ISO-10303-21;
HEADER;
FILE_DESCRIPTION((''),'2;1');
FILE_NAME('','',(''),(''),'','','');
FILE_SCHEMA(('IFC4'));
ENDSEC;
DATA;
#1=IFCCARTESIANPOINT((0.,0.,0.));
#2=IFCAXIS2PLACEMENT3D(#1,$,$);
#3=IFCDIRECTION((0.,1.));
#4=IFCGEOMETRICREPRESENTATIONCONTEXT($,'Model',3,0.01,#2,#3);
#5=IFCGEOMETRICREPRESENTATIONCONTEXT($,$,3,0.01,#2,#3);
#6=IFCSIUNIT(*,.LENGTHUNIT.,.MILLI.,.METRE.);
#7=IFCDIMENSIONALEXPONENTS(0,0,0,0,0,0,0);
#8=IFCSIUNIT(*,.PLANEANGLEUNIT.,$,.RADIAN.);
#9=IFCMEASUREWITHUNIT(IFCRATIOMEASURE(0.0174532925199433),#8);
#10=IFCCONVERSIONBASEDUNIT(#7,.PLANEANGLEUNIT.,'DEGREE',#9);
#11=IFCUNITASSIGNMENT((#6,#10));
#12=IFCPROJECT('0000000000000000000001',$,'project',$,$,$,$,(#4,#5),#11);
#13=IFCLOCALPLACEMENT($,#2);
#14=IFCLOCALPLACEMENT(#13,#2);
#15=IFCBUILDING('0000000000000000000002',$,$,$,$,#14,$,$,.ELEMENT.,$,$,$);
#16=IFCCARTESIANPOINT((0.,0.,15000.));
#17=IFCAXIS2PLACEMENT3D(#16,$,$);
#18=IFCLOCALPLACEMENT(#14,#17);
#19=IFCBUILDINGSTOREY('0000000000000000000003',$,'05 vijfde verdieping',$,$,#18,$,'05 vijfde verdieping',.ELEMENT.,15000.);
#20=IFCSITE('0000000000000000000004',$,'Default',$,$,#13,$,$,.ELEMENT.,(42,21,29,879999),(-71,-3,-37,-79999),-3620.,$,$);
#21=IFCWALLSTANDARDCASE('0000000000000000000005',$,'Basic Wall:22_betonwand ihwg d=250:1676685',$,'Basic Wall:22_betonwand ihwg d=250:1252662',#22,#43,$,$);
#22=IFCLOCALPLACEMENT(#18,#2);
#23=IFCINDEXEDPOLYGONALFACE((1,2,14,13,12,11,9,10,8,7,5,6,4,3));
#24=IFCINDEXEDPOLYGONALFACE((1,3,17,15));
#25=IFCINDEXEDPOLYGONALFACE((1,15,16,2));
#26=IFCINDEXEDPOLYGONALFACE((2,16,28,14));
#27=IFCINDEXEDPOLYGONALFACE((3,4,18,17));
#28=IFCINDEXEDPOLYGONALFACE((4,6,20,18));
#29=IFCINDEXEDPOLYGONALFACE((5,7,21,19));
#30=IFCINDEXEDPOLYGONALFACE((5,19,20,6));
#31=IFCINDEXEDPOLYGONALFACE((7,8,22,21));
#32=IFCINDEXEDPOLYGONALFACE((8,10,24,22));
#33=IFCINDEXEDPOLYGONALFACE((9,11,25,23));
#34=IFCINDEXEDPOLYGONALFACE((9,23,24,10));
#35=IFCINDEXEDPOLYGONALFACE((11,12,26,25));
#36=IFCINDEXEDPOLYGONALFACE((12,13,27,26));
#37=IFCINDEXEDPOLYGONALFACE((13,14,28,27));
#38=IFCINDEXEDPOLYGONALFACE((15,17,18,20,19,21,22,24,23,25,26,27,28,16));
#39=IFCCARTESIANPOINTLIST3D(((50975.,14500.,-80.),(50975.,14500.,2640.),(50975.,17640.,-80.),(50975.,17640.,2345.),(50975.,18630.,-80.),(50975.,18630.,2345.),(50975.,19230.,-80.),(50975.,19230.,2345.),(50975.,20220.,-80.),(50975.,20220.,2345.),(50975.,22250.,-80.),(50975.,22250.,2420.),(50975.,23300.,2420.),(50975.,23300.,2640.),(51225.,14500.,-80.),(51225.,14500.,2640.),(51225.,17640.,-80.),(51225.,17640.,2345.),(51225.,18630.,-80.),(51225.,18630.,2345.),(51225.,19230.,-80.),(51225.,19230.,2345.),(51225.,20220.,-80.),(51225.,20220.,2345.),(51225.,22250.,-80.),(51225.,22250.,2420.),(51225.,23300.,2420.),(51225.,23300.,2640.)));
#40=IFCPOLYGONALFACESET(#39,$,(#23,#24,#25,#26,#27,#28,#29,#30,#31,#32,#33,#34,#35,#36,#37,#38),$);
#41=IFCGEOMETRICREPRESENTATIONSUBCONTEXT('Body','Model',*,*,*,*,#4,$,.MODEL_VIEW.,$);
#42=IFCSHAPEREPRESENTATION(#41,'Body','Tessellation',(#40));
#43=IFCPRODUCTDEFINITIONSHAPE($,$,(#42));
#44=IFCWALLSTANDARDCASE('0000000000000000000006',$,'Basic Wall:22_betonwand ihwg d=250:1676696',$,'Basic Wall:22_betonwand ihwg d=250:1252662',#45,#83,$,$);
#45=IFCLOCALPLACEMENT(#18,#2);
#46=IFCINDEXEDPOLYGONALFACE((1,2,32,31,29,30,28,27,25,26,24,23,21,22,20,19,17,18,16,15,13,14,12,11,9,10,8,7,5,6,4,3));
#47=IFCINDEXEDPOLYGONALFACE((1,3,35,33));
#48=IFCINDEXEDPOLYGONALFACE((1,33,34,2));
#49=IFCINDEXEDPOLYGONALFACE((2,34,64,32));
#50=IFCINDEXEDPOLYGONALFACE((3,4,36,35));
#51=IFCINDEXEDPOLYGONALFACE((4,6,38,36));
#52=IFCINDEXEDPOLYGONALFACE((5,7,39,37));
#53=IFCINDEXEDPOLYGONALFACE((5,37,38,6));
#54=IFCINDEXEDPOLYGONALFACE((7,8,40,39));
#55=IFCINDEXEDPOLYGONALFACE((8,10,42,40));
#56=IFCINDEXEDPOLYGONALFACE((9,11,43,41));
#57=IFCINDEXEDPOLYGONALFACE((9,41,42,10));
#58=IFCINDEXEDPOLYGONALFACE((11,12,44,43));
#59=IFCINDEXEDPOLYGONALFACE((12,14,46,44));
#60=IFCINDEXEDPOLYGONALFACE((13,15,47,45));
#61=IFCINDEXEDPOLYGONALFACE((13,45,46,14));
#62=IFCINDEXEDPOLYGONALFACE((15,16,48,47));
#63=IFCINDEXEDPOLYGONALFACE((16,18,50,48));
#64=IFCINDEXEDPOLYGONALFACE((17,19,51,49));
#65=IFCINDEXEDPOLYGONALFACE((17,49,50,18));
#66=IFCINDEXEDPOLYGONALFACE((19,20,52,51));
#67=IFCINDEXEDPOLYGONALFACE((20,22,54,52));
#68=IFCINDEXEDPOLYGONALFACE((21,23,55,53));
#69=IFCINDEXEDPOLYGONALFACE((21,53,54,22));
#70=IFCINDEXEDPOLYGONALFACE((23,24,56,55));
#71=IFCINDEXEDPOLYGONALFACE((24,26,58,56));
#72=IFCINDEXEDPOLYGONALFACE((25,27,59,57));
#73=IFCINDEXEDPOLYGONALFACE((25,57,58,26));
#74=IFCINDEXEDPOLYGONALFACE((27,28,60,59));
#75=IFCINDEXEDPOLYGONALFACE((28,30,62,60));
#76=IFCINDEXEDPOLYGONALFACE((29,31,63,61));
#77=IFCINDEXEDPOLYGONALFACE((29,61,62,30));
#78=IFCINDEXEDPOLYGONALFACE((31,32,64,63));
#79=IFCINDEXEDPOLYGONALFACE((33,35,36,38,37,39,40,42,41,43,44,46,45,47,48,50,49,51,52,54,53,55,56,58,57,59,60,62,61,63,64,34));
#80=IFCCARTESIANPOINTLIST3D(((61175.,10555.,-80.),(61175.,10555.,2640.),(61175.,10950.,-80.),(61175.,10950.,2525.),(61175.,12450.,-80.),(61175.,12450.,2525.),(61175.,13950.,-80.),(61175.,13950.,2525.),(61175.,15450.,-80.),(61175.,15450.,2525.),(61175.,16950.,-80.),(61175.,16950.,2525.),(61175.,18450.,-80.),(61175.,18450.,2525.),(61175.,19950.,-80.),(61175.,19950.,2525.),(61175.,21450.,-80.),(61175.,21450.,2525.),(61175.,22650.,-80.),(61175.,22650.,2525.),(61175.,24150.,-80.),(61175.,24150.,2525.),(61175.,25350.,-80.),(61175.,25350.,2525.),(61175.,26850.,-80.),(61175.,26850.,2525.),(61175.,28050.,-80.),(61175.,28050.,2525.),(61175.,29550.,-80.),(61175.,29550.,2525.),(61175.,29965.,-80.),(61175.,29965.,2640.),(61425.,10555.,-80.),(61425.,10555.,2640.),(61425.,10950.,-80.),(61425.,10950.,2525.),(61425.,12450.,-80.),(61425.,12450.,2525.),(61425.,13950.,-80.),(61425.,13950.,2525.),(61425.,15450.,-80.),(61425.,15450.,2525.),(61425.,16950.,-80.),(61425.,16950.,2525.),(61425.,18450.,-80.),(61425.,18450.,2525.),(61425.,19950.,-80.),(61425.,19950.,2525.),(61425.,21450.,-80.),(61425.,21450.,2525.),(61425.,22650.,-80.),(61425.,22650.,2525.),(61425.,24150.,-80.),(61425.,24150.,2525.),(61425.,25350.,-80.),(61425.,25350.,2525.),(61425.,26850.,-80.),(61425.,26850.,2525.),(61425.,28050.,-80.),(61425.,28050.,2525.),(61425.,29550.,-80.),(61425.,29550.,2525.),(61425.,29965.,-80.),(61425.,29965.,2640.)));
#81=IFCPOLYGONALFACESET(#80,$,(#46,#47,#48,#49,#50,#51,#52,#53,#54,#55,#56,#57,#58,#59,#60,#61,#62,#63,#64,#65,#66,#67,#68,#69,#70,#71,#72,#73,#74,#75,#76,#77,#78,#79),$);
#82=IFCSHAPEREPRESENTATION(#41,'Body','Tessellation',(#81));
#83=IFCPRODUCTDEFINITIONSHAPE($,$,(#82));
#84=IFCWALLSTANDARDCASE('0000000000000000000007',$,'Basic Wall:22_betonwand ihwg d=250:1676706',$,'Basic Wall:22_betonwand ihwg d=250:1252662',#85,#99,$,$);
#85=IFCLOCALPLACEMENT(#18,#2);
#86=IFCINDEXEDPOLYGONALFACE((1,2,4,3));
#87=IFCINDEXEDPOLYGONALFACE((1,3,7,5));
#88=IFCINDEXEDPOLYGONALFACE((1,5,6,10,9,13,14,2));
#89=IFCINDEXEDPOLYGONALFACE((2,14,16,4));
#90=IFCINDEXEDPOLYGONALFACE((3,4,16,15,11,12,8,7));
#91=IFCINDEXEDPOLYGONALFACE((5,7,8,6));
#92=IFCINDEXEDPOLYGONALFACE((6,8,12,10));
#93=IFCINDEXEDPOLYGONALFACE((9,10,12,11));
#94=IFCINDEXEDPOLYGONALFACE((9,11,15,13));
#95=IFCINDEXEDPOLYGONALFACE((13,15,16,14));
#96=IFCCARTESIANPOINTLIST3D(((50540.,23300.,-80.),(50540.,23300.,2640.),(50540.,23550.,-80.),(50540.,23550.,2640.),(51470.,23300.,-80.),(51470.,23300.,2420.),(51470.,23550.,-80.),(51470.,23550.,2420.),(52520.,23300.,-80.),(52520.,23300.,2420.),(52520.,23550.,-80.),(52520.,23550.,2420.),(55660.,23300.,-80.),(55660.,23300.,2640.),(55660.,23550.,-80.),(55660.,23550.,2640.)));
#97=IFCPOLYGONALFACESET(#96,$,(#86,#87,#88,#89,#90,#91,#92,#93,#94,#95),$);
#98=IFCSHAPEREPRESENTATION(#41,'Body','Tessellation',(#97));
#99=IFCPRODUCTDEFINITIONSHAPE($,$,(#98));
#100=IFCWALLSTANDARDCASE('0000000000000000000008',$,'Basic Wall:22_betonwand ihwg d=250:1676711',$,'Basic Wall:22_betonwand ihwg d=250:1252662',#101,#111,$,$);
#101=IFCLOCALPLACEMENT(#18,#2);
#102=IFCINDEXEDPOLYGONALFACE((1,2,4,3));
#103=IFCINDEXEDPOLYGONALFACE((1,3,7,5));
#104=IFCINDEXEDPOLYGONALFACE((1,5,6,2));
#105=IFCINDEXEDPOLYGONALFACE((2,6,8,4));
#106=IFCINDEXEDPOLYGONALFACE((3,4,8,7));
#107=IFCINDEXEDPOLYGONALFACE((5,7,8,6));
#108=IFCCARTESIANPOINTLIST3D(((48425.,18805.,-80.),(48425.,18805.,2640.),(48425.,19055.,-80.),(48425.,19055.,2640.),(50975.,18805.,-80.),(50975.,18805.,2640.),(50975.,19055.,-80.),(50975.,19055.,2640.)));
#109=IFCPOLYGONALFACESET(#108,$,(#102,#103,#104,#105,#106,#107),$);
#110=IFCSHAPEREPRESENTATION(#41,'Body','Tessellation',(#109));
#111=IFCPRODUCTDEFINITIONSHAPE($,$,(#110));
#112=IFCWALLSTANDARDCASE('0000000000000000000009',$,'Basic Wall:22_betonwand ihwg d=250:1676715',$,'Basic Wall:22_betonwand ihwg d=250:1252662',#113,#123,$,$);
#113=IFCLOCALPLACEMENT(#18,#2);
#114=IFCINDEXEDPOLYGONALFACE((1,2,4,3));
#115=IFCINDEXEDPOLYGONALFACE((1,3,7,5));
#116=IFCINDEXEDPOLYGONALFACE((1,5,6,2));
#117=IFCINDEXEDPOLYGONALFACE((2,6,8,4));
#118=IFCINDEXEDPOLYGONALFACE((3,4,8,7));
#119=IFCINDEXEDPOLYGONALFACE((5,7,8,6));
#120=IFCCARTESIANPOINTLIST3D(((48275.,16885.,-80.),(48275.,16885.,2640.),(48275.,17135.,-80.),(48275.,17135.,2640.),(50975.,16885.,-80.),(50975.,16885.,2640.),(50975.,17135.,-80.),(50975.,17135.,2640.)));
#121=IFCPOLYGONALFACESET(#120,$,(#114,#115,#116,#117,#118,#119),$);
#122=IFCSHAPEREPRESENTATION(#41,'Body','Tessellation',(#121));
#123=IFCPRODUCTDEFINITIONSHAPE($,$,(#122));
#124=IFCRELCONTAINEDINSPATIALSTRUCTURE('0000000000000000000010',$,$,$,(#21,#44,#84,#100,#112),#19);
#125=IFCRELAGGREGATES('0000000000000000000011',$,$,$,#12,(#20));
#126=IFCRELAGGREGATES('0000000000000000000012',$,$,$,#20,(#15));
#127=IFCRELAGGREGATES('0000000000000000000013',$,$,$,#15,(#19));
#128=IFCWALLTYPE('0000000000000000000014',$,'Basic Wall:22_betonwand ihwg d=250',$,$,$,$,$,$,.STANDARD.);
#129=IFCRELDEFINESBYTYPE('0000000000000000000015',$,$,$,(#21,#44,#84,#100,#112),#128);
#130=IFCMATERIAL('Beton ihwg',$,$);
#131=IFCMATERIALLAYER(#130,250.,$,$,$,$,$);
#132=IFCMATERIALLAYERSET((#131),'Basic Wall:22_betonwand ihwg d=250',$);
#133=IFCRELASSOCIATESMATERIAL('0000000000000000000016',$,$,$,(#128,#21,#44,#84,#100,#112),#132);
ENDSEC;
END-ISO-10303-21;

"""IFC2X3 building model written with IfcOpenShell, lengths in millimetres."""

from ifc_helpers import new_model, entity, si_unit, converted_unit, direction, frame, frame_2d, origin, origin_2d_with_axis, place, context, subcontext, project, spatial, rectangle, extrude, material, layer, layer_set, layer_usage, type_object, element, save


model = new_model("IFC2X3")

# Units and contexts
model_context = context("Model", 3, precision=0.01, world=origin(), true_north=direction((0.0, 1.0)))
context_of_model = context(None, 3, precision=0.01, world=origin(), true_north=direction((0.0, 1.0)))
body_context = subcontext(model_context, "Body", "Model", "MODEL_VIEW")
ifc_project = project(units=[si_unit("LENGTHUNIT", "METRE", prefix="MILLI"), converted_unit("PLANEANGLEUNIT", "DEGREE", entity("IfcRatioMeasure", 0.0174532925199433), si_unit("PLANEANGLEUNIT", "RADIAN"), dimensions=[0, 0, 0, 0, 0, 0, 0])], contexts=[model_context, context_of_model])

# Site, building, storey
site_placement = place(None, origin())
site = spatial("IfcSite", under=ifc_project, at=site_placement, Name="Default", CompositionType="ELEMENT", RefLatitude=(42, 21, 29, 879999), RefLongitude=(-71, -3, -37, -79999), RefElevation=-3620.0)
building_placement = place(site_placement, origin())
building = spatial("IfcBuilding", under=site, at=building_placement, CompositionType="ELEMENT")
storey_placement = place(building_placement, frame((0.0, 0.0, 15000.0)))
storey = spatial("IfcBuildingStorey", under=building, at=storey_placement, Name="05 vijfde verdieping", LongName="05 vijfde verdieping", CompositionType="ELEMENT", Elevation=15000.0)

# Walls, openings
ifc_material_1 = material(Name="Beton ihwg")
ifc_layer_1 = layer(ifc_material_1, 250.0)
ifc_layer_set_1 = layer_set([ifc_layer_1], Name="Basic Wall:22_betonwand ihwg d=250")
ifc_layer_usage_1 = layer_usage(ifc_layer_set_1, "AXIS2", "NEGATIVE", 125.0)
wall_type_1 = type_object("IfcWallType", Name="Basic Wall:22_betonwand ihwg d=250", PredefinedType="STANDARD", material=ifc_layer_set_1)
wall_1_placement = place(storey_placement, frame((51100.0, 23300.0, -80.0), z_axis=(0.0, 0.0, 1.0), x_axis=(0.0, -1.0, 0.0)))
wall_1 = element("IfcWallStandardCase", 1, at=wall_1_placement, inside=storey, type_object=wall_type_1, material=ifc_layer_usage_1, Name="Basic Wall:22_betonwand ihwg d=250:1676685", ObjectType="Basic Wall:22_betonwand ihwg d=250:1252662", context=body_context, shape_type="SweptSolid", body=[
    extrude(rectangle(XDim=8800.0, YDim=250.0, at=frame_2d((4400.0, 0.0), x_axis=(-1.0, 0.0))), origin(), (0.0, 0.0, 1.0), 2720.0),
])
opening_1_placement = place(wall_1_placement, frame((23300.0, -51100.0, 80.0), z_axis=(0.0, 0.0, 1.0), x_axis=(0.0, 1.0, 0.0)))
element("IfcOpeningElement", 2, at=opening_1_placement, cuts=wall_1, ObjectType="Opening", context=body_context, shape_type="SweptSolid", body=[
    extrude(rectangle(XDim=2425.0, YDim=990.0, at=frame_2d((0.0, 0.0), x_axis=(1.0, 0.0))), frame((50700.0, 19725.0, 1132.5), z_axis=(1.0, 0.0, 0.0), x_axis=(0.0, 0.0, -1.0)), (0.0, 0.0, 1.0), 800.0),
])
opening_2_placement = place(wall_1_placement, frame((23300.0, -51100.0, 80.0), z_axis=(0.0, 0.0, 1.0), x_axis=(0.0, 1.0, 0.0)))
element("IfcOpeningElement", 3, at=opening_2_placement, cuts=wall_1, ObjectType="Opening", context=body_context, shape_type="SweptSolid", body=[
    extrude(rectangle(XDim=2425.0, YDim=990.0, at=origin_2d_with_axis()), frame((50700.0, 18135.0, 1132.5), z_axis=(1.0, 0.0, 0.0), x_axis=(0.0, 0.0, -1.0)), (0.0, 0.0, 1.0), 800.0),
])
opening_3_placement = place(wall_1_placement, frame((23300.0, -51100.0, 80.0), z_axis=(0.0, 0.0, 1.0), x_axis=(0.0, 1.0, 0.0)))
element("IfcOpeningElement", 4, at=opening_3_placement, cuts=wall_1, ObjectType="Opening", context=body_context, shape_type="SweptSolid", body=[
    extrude(rectangle(XDim=2500.0, YDim=1050.0, at=frame_2d((0.0, 0.0), x_axis=(1.0, 0.0))), frame((50700.0, 22775.0, 1170.0), z_axis=(1.0, 0.0, 0.0), x_axis=(0.0, 0.0, -1.0)), (0.0, 0.0, 1.0), 800.0),
])
ifc_layer_usage_2 = layer_usage(ifc_layer_set_1, "AXIS2", "POSITIVE", -125.0)
wall_2_placement = place(storey_placement, frame((61300.0, 29965.0, -80.0), z_axis=(0.0, 0.0, 1.0), x_axis=(0.0, -1.0, 0.0)))
wall_2 = element("IfcWallStandardCase", 5, at=wall_2_placement, inside=storey, type_object=wall_type_1, material=ifc_layer_usage_2, Name="Basic Wall:22_betonwand ihwg d=250:1676696", ObjectType="Basic Wall:22_betonwand ihwg d=250:1252662", context=body_context, shape_type="SweptSolid", body=[
    extrude(rectangle(XDim=19410.0, YDim=250.0, at=frame_2d((9705.0, 0.0), x_axis=(-1.0, 0.0))), origin(), (0.0, 0.0, 1.0), 2720.0),
])
opening_4_placement = place(wall_2_placement, frame((29965.0, -61300.0, 80.0), z_axis=(0.0, 0.0, 1.0), x_axis=(0.0, 1.0, 0.0)))
element("IfcOpeningElement", 6, at=opening_4_placement, cuts=wall_2, ObjectType="Opening", context=body_context, shape_type="SweptSolid", body=[
    extrude(rectangle(XDim=2605.0, YDim=1500.0, at=frame_2d((0.0, 0.0), x_axis=(1.0, 0.0))), frame((59901.0, 28800.0, 1222.5), z_axis=(1.0, 0.0, 0.0), x_axis=(0.0, 0.0, -1.0)), (0.0, 0.0, 1.0), 3048.0),
])
opening_5_placement = place(wall_2_placement, frame((29965.0, -61300.0, 80.0), z_axis=(0.0, 0.0, 1.0), x_axis=(0.0, 1.0, 0.0)))
element("IfcOpeningElement", 7, at=opening_5_placement, cuts=wall_2, ObjectType="Opening", context=body_context, shape_type="SweptSolid", body=[
    extrude(rectangle(XDim=2605.0, YDim=1500.0, at=frame_2d((0.0, 0.0), x_axis=(1.0, 0.0))), frame((59901.0, 26100.0, 1222.5), z_axis=(1.0, 0.0, 0.0), x_axis=(0.0, 0.0, -1.0)), (0.0, 0.0, 1.0), 3048.0),
])
opening_6_placement = place(wall_2_placement, frame((29965.0, -61300.0, 80.0), z_axis=(0.0, 0.0, 1.0), x_axis=(0.0, 1.0, 0.0)))
element("IfcOpeningElement", 8, at=opening_6_placement, cuts=wall_2, ObjectType="Opening", context=body_context, shape_type="SweptSolid", body=[
    extrude(rectangle(XDim=2605.0, YDim=1500.0, at=frame_2d((0.0, 0.0), x_axis=(1.0, 0.0))), frame((59901.0, 23400.0, 1222.5), z_axis=(1.0, 0.0, 0.0), x_axis=(0.0, 0.0, -1.0)), (0.0, 0.0, 1.0), 3048.0),
])
opening_7_placement = place(wall_2_placement, frame((29965.0, -61300.0, 80.0), z_axis=(0.0, 0.0, 1.0), x_axis=(0.0, 1.0, 0.0)))
element("IfcOpeningElement", 9, at=opening_7_placement, cuts=wall_2, ObjectType="Opening", context=body_context, shape_type="SweptSolid", body=[
    extrude(rectangle(XDim=2605.0, YDim=1500.0, at=frame_2d((0.0, 0.0), x_axis=(1.0, 0.0))), frame((59901.0, 17700.0, 1222.5), z_axis=(1.0, 0.0, 0.0), x_axis=(0.0, 0.0, -1.0)), (0.0, 0.0, 1.0), 3048.0),
])
opening_8_placement = place(wall_2_placement, frame((29965.0, -61300.0, 80.0), z_axis=(0.0, 0.0, 1.0), x_axis=(0.0, 1.0, 0.0)))
element("IfcOpeningElement", 10, at=opening_8_placement, cuts=wall_2, ObjectType="Opening", context=body_context, shape_type="SweptSolid", body=[
    extrude(rectangle(XDim=2605.0, YDim=1500.0, at=frame_2d((0.0, 0.0), x_axis=(1.0, 0.0))), frame((59901.0, 14700.0, 1222.5), z_axis=(1.0, 0.0, 0.0), x_axis=(0.0, 0.0, -1.0)), (0.0, 0.0, 1.0), 3048.0),
])
opening_9_placement = place(wall_2_placement, frame((29965.0, -61300.0, 80.0), z_axis=(0.0, 0.0, 1.0), x_axis=(0.0, 1.0, 0.0)))
element("IfcOpeningElement", 11, at=opening_9_placement, cuts=wall_2, ObjectType="Opening", context=body_context, shape_type="SweptSolid", body=[
    extrude(rectangle(XDim=2605.0, YDim=1500.0, at=frame_2d((0.0, 0.0), x_axis=(1.0, 0.0))), frame((59901.0, 20700.0, 1222.5), z_axis=(1.0, 0.0, 0.0), x_axis=(0.0, 0.0, -1.0)), (0.0, 0.0, 1.0), 3048.0),
])
opening_10_placement = place(wall_2_placement, frame((29965.0, -61300.0, 80.0), z_axis=(0.0, 0.0, 1.0), x_axis=(0.0, 1.0, 0.0)))
element("IfcOpeningElement", 12, at=opening_10_placement, cuts=wall_2, ObjectType="Opening", context=body_context, shape_type="SweptSolid", body=[
    extrude(rectangle(XDim=2605.0, YDim=1500.0, at=frame_2d((0.0, 0.0), x_axis=(1.0, 0.0))), frame((59901.0, 11700.0, 1222.5), z_axis=(1.0, 0.0, 0.0), x_axis=(0.0, 0.0, -1.0)), (0.0, 0.0, 1.0), 3048.0),
])
ifc_layer_usage_3 = layer_usage(ifc_layer_set_1, "AXIS2", "POSITIVE", -125.0)
wall_3_placement = place(storey_placement, frame((55660.0, 23425.0, -80.0), z_axis=(0.0, 0.0, 1.0), x_axis=(-1.0, 0.0, 0.0)))
wall_3 = element("IfcWallStandardCase", 13, at=wall_3_placement, inside=storey, type_object=wall_type_1, material=ifc_layer_usage_3, Name="Basic Wall:22_betonwand ihwg d=250:1676706", ObjectType="Basic Wall:22_betonwand ihwg d=250:1252662", context=body_context, shape_type="SweptSolid", body=[
    extrude(rectangle(XDim=5120.0, YDim=250.0, at=frame_2d((2560.0, 0.0), x_axis=(-1.0, 0.0))), origin(), (0.0, 0.0, 1.0), 2720.0),
])
opening_11_placement = place(wall_3_placement, origin())
element("IfcOpeningElement", 14, at=opening_11_placement, cuts=wall_3, ObjectType="Opening", context=body_context, shape_type="SweptSolid", body=[
    extrude(rectangle(XDim=2500.0, YDim=800.0, at=frame_2d((0.0, 0.0), x_axis=(0.0, 1.0))), frame((4560.0, 125.0, 1250.0), z_axis=(0.0, 1.0, 0.0), x_axis=(1.0, 0.0, 0.0)), (0.0, 0.0, 1.0), 1050.0),
])
opening_12_placement = place(wall_3_placement, origin())
element("IfcOpeningElement", 15, at=opening_12_placement, cuts=wall_3, ObjectType="Opening", context=body_context, shape_type="SweptSolid", body=[
    extrude(rectangle(XDim=2500.0, YDim=800.0, at=frame_2d((0.0, 0.0), x_axis=(0.0, 1.0))), frame((2735.0, 125.0, 1250.0), z_axis=(0.0, 1.0, 0.0), x_axis=(1.0, 0.0, 0.0)), (0.0, 0.0, 1.0), 1034.0),
])
opening_13_placement = place(wall_3_placement, frame((55660.0, 23425.0, 80.0), z_axis=(0.0, 0.0, 1.0), x_axis=(-1.0, 0.0, 0.0)))
element("IfcOpeningElement", 16, at=opening_13_placement, cuts=wall_3, ObjectType="Opening", context=body_context, shape_type="SweptSolid", body=[
    extrude(rectangle(XDim=2500.0, YDim=1050.0, at=frame_2d((0.0, 0.0), x_axis=(0.0, 1.0))), frame((51995.0, 23825.0, 1170.0), z_axis=(0.0, -1.0, 0.0), x_axis=(-1.0, 0.0, 0.0)), (0.0, 0.0, 1.0), 800.0),
])

# Walls
ifc_layer_usage_4 = layer_usage(ifc_layer_set_1, "AXIS2", "POSITIVE", -125.0)
wall_4_placement = place(storey_placement, frame((50975.0, 18930.0, -80.0), z_axis=(0.0, 0.0, 1.0), x_axis=(-1.0, 0.0, 0.0)))
element("IfcWallStandardCase", 17, at=wall_4_placement, inside=storey, type_object=wall_type_1, material=ifc_layer_usage_4, Name="Basic Wall:22_betonwand ihwg d=250:1676711", ObjectType="Basic Wall:22_betonwand ihwg d=250:1252662", context=body_context, shape_type="SweptSolid", body=[
    extrude(rectangle(XDim=2550.0, YDim=250.0, at=frame_2d((1275.0, 0.0), x_axis=(-1.0, 0.0))), origin(), (0.0, 0.0, 1.0), 2720.0),
])
ifc_layer_usage_5 = layer_usage(ifc_layer_set_1, "AXIS2", "POSITIVE", -125.0)
wall_5_placement = place(storey_placement, frame((50975.0, 17010.0, -80.0), z_axis=(0.0, 0.0, 1.0), x_axis=(-1.0, 0.0, 0.0)))
element("IfcWallStandardCase", 18, at=wall_5_placement, inside=storey, type_object=wall_type_1, material=ifc_layer_usage_5, Name="Basic Wall:22_betonwand ihwg d=250:1676715", ObjectType="Basic Wall:22_betonwand ihwg d=250:1252662", context=body_context, shape_type="SweptSolid", body=[
    extrude(rectangle(XDim=2700.0, YDim=250.0, at=frame_2d((1350.0, 0.0), x_axis=(-1.0, 0.0))), origin(), (0.0, 0.0, 1.0), 2720.0),
])

save(model, "model.ifc")
